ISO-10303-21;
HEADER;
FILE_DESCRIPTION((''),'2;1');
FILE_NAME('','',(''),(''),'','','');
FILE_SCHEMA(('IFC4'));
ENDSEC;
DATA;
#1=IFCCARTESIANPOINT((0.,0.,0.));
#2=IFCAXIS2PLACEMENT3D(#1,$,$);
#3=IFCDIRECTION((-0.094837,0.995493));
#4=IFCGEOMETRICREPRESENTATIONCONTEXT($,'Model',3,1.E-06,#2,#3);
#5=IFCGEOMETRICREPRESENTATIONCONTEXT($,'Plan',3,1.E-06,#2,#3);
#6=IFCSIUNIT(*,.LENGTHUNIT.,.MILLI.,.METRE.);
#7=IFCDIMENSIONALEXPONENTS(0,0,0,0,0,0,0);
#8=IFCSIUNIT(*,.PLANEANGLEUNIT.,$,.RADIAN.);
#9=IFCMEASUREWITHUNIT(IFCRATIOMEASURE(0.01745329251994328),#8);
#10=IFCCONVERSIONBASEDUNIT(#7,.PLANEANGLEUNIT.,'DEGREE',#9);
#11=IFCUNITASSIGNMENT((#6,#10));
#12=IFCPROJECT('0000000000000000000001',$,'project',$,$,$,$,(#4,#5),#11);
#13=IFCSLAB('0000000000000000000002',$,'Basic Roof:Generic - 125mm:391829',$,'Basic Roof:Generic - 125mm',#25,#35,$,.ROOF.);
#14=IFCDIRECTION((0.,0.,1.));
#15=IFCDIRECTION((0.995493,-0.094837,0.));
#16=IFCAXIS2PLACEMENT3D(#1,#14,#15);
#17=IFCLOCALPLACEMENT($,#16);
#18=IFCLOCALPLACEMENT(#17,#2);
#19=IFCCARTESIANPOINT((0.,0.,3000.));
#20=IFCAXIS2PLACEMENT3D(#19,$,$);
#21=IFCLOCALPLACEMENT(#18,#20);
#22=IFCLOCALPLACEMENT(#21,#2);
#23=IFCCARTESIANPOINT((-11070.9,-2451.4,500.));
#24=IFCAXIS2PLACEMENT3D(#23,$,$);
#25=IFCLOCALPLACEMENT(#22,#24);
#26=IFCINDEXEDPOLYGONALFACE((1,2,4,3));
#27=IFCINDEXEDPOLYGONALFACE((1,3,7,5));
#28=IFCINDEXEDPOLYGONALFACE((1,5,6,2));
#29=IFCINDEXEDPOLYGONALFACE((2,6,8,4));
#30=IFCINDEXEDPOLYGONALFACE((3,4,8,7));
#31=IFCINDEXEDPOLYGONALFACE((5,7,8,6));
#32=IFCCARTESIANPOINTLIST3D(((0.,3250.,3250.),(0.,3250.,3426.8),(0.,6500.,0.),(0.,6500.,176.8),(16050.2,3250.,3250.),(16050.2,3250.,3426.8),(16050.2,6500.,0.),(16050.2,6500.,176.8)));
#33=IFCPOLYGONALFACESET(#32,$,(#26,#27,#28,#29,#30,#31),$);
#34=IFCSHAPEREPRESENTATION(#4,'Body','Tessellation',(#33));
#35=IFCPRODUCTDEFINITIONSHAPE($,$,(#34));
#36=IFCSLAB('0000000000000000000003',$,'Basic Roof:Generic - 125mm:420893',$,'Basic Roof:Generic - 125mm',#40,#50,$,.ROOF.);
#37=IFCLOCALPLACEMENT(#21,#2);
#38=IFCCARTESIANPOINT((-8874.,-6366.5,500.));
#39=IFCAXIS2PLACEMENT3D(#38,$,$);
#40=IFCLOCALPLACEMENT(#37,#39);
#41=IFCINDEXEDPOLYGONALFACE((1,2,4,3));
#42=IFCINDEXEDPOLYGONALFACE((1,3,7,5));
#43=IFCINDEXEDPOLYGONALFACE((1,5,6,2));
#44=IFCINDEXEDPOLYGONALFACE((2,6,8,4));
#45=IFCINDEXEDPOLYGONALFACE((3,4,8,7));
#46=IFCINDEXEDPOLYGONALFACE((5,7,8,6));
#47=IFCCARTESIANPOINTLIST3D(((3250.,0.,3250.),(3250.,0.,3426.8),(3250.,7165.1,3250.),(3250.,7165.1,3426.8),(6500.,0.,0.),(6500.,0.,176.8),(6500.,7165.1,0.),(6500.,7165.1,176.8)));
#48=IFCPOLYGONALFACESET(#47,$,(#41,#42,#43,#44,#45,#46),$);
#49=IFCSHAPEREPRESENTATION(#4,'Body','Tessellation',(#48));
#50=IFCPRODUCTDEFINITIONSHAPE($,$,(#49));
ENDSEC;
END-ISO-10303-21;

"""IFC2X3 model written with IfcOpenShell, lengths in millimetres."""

from ifc_helpers import new_model, entity, si_unit, converted_unit, direction, frame, frame_2d, origin, origin_2d_with_axis, place, context, project, rectangle, extrude, element, save


model = new_model("IFC2X3")

# Units and contexts
model_context = context("Model", 3, precision=1e-06, world=origin(), true_north=direction((-0.094837, 0.995493)))
plan_context = context("Plan", 3, precision=1e-06, world=origin(), true_north=direction((-0.094837, 0.995493)))
ifc_project = project(units=[si_unit("LENGTHUNIT", "METRE", prefix="MILLI"), converted_unit("PLANEANGLEUNIT", "DEGREE", entity("IfcRatioMeasure", 0.01745329251994328), si_unit("PLANEANGLEUNIT", "RADIAN"), dimensions=[0, 0, 0, 0, 0, 0, 0])], contexts=[model_context, plan_context])

# Slabs
placement_1 = place(None, frame((0.0, 0.0, 0.0), z_axis=(0.0, 0.0, 1.0), x_axis=(0.995493, -0.094837, 0.0)))
placement_2 = place(placement_1, origin())
placement_3 = place(placement_2, frame((0.0, 0.0, 3000.0)))
placement_4 = place(placement_3, origin())
slab_1_placement = place(placement_4, frame((-11070.9, -2451.4, 500.0)))
element("IfcSlab", 1, at=slab_1_placement, Name="Basic Roof:Generic - 125mm:391829", ObjectType="Basic Roof:Generic - 125mm", PredefinedType="ROOF", context=model_context, shape_type="SweptSolid", body=[
    extrude(rectangle(XDim=16050.2, YDim=4596.2, at=origin_2d_with_axis()), frame((8025.1, 4875.0, 1625.0), z_axis=(0.0, 0.707107, 0.707107), x_axis=(1.0, 0.0, 0.0)), (0.0, -0.707107, 0.707107), 176.8),
])
placement_5 = place(placement_3, origin())
slab_2_placement = place(placement_5, frame((-8874.0, -6366.5, 500.0)))
element("IfcSlab", 2, at=slab_2_placement, Name="Basic Roof:Generic - 125mm:420893", ObjectType="Basic Roof:Generic - 125mm", PredefinedType="ROOF", context=model_context, shape_type="SweptSolid", body=[
    extrude(rectangle(XDim=7165.1, YDim=4596.2, at=frame_2d((0.0, 0.0), x_axis=(0.0, -1.0))), frame((4875.0, 3582.6, 1625.0), z_axis=(0.707107, 0.0, 0.707107), x_axis=(0.707107, 0.0, -0.707107)), (-0.707107, 0.0, 0.707107), 176.8),
])

save(model, "model.ifc")
